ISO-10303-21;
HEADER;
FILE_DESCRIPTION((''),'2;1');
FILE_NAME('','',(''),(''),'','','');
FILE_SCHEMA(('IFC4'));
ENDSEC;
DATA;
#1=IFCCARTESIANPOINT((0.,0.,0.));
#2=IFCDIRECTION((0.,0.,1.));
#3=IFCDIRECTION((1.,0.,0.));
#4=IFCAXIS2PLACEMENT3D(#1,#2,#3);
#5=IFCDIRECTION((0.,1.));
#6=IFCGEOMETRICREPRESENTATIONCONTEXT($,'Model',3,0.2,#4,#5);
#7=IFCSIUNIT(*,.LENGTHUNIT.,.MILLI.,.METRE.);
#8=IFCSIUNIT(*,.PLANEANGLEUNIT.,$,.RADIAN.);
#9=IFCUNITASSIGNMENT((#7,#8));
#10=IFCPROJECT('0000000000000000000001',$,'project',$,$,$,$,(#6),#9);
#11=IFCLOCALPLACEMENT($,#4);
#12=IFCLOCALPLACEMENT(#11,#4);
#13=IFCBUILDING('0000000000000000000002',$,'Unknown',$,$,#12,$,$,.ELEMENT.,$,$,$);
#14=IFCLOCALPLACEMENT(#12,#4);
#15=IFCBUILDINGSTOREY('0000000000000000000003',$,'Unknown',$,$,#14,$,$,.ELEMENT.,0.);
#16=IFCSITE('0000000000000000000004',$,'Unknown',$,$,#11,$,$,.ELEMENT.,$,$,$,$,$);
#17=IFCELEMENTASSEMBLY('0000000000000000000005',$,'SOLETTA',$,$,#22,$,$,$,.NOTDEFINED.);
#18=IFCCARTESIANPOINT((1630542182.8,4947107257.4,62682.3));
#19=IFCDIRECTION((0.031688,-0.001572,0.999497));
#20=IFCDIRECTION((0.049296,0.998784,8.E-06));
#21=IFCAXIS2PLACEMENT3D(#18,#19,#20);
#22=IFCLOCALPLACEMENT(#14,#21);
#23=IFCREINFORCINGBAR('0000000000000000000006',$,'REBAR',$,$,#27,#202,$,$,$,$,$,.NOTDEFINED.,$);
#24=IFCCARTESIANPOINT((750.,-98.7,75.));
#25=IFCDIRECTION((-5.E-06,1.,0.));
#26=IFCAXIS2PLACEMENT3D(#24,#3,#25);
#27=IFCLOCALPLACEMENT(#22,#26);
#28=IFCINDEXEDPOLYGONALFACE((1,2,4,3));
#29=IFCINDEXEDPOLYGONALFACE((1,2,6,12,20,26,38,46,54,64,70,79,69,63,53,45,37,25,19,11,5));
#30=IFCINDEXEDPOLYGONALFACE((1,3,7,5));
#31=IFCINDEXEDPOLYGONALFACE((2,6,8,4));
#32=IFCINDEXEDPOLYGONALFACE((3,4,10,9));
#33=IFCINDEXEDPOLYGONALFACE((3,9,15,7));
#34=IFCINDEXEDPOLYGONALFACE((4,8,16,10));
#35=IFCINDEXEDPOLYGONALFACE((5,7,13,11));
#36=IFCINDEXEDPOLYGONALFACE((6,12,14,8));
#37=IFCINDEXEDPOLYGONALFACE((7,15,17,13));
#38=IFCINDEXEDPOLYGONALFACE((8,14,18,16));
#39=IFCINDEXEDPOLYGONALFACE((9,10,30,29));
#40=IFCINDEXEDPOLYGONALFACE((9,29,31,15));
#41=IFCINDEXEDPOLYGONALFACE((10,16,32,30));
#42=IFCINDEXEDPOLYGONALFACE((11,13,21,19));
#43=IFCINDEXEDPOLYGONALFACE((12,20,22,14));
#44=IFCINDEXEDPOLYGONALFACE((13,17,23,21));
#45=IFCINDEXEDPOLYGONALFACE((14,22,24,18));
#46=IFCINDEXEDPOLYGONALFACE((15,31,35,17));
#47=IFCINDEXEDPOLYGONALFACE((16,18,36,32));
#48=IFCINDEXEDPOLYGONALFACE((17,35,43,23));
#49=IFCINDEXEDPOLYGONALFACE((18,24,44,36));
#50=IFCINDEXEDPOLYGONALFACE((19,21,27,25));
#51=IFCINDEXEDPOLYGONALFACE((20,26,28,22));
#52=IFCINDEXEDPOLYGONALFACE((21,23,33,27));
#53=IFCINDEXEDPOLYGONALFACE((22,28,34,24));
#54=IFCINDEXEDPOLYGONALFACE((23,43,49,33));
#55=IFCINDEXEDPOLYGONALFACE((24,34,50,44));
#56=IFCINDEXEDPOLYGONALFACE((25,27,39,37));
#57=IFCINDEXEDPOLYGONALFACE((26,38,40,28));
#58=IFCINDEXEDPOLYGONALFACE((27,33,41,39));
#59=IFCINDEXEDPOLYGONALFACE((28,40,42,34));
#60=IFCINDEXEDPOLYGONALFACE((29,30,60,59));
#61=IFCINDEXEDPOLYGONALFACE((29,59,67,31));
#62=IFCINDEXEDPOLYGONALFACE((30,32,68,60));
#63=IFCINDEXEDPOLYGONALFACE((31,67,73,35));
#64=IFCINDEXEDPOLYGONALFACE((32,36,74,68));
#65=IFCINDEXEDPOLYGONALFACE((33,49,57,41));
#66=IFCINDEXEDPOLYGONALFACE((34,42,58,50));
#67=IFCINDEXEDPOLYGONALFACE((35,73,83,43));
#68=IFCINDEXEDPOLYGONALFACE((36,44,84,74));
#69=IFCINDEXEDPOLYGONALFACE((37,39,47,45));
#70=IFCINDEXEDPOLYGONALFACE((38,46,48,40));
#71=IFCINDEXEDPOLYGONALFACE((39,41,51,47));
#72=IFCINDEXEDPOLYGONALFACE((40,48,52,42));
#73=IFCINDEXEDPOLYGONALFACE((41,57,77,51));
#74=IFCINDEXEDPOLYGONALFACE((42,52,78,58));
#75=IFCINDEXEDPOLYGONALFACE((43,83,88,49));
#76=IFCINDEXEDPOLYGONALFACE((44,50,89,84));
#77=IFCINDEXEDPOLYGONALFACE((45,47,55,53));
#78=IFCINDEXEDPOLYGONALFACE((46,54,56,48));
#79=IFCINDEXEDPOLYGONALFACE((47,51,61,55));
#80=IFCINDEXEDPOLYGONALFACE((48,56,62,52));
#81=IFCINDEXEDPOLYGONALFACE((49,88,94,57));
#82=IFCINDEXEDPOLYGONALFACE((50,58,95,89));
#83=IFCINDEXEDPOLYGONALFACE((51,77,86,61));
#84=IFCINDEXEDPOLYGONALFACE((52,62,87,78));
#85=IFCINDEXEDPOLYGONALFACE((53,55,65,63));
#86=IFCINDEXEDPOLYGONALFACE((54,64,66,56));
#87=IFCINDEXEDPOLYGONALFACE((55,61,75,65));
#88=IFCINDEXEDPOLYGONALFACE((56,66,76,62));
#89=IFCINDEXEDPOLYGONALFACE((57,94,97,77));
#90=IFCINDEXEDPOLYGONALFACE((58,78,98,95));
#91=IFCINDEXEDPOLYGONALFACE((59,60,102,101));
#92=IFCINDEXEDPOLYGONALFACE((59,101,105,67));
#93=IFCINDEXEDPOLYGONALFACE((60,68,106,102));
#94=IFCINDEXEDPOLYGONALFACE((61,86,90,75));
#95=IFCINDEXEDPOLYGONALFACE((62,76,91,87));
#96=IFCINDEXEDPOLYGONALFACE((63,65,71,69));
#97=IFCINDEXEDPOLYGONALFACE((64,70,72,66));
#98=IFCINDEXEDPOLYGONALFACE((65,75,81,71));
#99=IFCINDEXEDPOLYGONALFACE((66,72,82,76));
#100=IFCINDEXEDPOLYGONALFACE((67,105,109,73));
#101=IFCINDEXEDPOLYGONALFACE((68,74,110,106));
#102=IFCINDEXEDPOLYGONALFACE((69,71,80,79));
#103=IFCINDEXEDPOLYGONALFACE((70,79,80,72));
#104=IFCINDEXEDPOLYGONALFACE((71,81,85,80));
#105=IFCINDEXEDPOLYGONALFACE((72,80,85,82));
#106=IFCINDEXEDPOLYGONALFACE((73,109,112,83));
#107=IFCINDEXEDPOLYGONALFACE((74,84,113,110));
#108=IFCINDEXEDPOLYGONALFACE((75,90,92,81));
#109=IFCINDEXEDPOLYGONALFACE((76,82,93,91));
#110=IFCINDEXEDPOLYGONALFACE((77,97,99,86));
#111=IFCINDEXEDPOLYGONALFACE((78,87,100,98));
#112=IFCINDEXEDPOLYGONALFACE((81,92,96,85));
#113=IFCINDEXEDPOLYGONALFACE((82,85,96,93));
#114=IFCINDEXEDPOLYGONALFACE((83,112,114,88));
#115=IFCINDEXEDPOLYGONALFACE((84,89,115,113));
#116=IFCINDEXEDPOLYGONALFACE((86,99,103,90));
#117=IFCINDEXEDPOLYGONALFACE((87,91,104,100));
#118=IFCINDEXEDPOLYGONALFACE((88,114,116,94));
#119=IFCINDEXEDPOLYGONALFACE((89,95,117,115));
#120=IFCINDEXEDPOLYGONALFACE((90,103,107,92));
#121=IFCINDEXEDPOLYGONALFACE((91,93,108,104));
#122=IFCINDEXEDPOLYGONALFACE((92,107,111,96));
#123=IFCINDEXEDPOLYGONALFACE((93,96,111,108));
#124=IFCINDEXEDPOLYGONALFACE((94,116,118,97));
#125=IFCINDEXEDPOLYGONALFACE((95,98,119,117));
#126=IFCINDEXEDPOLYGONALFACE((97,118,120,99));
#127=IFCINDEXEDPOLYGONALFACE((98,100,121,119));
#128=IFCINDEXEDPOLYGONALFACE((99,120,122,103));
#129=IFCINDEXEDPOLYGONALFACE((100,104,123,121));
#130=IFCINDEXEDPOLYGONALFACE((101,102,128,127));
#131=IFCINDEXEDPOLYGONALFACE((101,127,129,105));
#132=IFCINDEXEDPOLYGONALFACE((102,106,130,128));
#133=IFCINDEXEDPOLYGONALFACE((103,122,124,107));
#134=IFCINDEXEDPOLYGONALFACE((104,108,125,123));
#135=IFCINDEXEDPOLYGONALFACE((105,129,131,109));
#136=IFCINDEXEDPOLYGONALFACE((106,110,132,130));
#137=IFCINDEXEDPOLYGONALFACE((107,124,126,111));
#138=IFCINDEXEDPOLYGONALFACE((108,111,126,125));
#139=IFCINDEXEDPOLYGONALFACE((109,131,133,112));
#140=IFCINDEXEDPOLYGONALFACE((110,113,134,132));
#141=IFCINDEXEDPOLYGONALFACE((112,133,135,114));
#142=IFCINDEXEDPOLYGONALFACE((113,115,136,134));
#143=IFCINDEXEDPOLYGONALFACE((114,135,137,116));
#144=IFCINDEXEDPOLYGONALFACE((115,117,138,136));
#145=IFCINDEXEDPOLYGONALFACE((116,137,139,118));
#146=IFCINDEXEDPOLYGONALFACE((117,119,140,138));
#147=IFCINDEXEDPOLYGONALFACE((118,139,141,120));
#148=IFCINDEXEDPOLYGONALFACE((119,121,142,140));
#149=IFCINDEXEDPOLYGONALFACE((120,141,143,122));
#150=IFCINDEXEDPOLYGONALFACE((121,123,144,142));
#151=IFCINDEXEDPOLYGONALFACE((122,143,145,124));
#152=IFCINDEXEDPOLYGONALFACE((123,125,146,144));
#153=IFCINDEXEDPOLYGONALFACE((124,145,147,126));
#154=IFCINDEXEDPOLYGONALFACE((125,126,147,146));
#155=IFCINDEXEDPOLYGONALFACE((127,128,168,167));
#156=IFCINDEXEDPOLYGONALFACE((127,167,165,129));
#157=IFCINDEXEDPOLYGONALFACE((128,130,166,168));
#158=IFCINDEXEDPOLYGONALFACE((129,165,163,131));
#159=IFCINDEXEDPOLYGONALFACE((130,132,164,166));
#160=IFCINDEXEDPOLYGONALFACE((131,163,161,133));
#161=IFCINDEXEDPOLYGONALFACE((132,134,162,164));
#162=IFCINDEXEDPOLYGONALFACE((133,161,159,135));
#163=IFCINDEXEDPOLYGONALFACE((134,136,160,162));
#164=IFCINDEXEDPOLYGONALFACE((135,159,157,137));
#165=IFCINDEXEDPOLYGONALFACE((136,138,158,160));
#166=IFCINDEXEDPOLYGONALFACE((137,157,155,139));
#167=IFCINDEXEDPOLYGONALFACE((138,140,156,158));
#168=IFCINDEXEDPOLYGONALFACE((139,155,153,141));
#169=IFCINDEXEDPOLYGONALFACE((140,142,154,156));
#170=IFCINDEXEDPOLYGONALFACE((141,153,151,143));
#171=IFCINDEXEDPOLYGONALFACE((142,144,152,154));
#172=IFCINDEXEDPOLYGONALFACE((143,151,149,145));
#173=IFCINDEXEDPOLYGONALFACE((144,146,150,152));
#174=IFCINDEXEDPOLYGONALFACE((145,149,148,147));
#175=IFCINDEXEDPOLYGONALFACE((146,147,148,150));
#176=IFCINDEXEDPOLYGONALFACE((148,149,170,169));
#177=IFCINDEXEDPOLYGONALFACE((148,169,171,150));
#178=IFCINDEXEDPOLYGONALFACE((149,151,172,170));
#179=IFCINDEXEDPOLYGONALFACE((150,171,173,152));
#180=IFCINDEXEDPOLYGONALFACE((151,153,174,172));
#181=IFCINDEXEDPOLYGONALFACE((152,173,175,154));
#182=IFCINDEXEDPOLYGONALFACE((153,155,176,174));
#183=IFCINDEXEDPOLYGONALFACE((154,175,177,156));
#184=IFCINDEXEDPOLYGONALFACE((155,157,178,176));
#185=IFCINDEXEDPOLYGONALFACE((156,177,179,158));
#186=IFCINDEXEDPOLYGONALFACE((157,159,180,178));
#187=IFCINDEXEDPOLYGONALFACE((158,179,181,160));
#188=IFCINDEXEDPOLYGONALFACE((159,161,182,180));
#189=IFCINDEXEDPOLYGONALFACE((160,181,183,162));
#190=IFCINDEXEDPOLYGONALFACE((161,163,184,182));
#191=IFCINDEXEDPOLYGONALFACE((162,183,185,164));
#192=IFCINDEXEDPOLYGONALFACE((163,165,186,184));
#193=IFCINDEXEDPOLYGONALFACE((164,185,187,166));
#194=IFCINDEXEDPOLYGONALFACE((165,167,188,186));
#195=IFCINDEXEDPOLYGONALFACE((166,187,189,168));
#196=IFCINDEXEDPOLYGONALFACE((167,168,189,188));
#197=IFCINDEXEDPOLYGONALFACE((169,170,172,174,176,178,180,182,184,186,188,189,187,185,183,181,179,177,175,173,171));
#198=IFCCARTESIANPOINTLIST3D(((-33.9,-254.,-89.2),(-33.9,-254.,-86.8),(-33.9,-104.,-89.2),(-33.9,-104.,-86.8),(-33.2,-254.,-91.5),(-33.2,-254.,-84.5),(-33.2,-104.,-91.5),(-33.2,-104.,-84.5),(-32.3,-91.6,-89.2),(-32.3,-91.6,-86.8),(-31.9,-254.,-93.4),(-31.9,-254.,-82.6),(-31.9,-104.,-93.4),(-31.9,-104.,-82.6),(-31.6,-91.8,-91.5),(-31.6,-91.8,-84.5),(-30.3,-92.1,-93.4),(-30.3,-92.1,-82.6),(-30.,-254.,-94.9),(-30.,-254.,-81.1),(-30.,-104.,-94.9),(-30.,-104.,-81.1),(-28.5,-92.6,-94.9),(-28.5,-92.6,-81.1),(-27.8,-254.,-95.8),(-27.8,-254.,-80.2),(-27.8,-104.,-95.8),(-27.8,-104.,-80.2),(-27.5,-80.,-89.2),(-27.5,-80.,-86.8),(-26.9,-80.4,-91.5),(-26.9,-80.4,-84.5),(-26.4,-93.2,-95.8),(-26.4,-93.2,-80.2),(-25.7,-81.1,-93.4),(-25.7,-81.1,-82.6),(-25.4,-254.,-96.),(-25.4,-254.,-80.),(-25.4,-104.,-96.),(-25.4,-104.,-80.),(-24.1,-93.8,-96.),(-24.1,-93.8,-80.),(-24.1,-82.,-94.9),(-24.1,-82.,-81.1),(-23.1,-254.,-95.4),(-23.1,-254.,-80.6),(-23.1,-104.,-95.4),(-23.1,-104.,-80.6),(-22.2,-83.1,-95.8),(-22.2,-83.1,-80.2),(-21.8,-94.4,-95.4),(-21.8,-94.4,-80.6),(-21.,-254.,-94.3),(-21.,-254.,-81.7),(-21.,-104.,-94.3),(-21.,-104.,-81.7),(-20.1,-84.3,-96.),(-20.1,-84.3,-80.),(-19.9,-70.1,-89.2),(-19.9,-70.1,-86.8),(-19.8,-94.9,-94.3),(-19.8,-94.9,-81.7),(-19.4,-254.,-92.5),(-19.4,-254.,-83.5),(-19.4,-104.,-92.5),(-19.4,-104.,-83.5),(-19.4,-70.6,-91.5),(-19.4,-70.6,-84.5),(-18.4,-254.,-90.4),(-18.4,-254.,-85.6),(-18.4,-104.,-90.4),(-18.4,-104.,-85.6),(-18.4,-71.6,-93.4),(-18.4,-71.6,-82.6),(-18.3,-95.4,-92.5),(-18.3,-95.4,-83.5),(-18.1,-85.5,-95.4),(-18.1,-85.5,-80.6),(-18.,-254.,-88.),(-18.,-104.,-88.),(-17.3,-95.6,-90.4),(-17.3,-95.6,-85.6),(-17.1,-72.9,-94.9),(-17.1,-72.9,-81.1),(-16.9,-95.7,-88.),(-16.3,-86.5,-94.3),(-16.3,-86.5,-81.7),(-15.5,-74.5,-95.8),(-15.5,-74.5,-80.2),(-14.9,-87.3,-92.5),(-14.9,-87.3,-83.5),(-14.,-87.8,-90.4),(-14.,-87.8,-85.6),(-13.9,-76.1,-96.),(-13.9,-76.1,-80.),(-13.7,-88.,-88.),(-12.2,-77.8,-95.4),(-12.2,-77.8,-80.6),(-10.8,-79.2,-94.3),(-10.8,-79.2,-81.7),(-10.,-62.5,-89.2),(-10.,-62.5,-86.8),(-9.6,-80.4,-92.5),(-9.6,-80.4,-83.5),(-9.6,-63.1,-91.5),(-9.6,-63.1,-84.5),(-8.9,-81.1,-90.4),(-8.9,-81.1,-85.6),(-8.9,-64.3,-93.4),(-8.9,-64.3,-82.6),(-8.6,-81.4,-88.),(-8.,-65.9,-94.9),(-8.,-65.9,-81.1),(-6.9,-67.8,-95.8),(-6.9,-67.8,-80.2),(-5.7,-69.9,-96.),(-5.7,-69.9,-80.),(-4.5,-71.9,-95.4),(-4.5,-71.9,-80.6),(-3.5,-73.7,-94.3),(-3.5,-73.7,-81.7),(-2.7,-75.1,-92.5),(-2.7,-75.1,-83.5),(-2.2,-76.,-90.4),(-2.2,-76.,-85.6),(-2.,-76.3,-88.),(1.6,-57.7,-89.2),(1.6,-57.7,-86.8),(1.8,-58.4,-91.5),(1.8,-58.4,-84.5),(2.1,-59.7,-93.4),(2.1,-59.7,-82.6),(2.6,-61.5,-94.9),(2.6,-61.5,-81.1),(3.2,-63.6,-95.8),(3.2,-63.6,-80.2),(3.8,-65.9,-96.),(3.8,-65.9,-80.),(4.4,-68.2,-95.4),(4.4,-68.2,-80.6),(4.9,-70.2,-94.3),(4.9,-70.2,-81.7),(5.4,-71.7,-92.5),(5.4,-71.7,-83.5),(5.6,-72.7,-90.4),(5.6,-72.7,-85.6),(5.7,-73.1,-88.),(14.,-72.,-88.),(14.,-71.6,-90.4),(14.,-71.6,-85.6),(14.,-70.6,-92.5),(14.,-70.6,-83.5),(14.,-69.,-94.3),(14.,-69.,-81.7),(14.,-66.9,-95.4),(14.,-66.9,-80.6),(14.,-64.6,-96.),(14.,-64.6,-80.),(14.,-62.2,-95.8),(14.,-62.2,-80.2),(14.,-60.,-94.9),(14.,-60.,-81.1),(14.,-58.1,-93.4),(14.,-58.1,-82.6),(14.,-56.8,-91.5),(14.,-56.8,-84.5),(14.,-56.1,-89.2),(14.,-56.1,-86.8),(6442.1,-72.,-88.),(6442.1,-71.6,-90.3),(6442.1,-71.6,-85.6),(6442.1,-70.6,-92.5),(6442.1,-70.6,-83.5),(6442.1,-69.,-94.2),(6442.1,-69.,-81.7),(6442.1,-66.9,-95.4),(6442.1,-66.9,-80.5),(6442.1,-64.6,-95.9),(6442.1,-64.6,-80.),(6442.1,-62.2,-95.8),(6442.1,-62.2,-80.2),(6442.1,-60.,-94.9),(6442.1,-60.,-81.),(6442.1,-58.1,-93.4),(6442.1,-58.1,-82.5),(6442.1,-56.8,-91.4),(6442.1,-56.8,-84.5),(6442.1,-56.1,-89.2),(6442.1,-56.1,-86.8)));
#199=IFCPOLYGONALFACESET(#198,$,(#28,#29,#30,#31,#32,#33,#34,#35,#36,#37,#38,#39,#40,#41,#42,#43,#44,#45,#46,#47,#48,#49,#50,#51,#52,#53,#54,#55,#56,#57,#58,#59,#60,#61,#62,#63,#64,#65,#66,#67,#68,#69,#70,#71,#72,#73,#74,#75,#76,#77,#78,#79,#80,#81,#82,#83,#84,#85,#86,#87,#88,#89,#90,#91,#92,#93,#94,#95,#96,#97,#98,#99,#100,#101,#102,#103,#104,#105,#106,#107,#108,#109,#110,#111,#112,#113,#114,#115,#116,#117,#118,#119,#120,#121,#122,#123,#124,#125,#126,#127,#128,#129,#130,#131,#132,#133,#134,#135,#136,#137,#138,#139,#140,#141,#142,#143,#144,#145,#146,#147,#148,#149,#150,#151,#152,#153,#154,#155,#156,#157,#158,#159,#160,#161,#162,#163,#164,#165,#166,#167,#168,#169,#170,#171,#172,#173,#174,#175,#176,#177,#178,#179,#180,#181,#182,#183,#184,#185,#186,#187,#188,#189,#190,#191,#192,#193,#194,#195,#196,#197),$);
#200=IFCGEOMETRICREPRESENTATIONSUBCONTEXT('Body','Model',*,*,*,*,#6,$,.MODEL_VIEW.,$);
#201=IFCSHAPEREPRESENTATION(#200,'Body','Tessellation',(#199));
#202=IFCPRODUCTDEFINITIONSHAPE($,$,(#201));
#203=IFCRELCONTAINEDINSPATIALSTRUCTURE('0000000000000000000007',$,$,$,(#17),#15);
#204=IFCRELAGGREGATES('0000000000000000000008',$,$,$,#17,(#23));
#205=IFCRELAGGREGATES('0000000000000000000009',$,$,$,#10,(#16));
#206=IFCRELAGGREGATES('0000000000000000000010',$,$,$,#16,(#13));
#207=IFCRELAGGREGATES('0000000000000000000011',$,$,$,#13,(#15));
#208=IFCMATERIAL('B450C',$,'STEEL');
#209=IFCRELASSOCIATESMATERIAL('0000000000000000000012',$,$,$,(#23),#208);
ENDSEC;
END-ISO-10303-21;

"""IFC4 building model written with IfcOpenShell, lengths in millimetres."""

from ifc_helpers import new_model, entity, si_unit, direction, frame, origin_with_axes, place, context, subcontext, project, spatial, material, element, aggregate, save


model = new_model("IFC4")

# Units and contexts
model_context = context("Model", 3, precision=0.2, world=origin_with_axes(), true_north=direction((0.0, 1.0)))
body_context = subcontext(model_context, "Body", "Model", "MODEL_VIEW")
ifc_project = project(units=[si_unit("LENGTHUNIT", "METRE", prefix="MILLI"), si_unit("PLANEANGLEUNIT", "RADIAN")], contexts=[model_context])

# Site, building, storey
site_placement = place(None, origin_with_axes())
site = spatial("IfcSite", under=ifc_project, at=site_placement, Name="Unknown", CompositionType="ELEMENT")
building_placement = place(site_placement, origin_with_axes())
building = spatial("IfcBuilding", under=site, at=building_placement, Name="Unknown", CompositionType="ELEMENT")
storey_placement = place(building_placement, origin_with_axes())
storey = spatial("IfcBuildingStorey", under=building, at=storey_placement, Name="Unknown", CompositionType="ELEMENT", Elevation=0.0)

# Element assembly, reinforcing bar
ifc_material = material(Name="B450C", Category="STEEL")
assembly_1_placement = place(storey_placement, frame((1630542182.8, 4947107257.4, 62682.3), z_axis=(0.031688, -0.001572, 0.999497), x_axis=(0.049296, 0.998784, 0.000008)))
assembly_1 = element("IfcElementAssembly", 1, at=assembly_1_placement, inside=storey, Name="SOLETTA", PredefinedType="NOTDEFINED")
reinforcing_bar_1_placement = place(assembly_1_placement, frame((750.0, -98.7, 75.0), z_axis=(1.0, 0.0, 0.0), x_axis=(-0.000005, 1.0, 0.0)))
reinforcing_bar_1 = element("IfcReinforcingBar", 2, at=reinforcing_bar_1_placement, material=ifc_material, Name="REBAR", PredefinedType="NOTDEFINED", context=body_context, shape_type="AdvancedSweptSolid", body=[
    entity("IfcSweptDiskSolid", entity("IfcIndexedPolyCurve", entity("IfcCartesianPointList3D", [[-26.0, -254.0, -88.0], [-26.0, -104.0, -88.0], [-14.3, -75.7, -88.0], [14.0, -64.0, -88.0], [6442.1, -64.0, -88.0]]), [entity("IfcLineIndex", [1, 2]), entity("IfcArcIndex", [2, 3, 4]), entity("IfcLineIndex", [4, 5])]), 8.0),
])
aggregate(assembly_1, [reinforcing_bar_1])

save(model, "model.ifc")
